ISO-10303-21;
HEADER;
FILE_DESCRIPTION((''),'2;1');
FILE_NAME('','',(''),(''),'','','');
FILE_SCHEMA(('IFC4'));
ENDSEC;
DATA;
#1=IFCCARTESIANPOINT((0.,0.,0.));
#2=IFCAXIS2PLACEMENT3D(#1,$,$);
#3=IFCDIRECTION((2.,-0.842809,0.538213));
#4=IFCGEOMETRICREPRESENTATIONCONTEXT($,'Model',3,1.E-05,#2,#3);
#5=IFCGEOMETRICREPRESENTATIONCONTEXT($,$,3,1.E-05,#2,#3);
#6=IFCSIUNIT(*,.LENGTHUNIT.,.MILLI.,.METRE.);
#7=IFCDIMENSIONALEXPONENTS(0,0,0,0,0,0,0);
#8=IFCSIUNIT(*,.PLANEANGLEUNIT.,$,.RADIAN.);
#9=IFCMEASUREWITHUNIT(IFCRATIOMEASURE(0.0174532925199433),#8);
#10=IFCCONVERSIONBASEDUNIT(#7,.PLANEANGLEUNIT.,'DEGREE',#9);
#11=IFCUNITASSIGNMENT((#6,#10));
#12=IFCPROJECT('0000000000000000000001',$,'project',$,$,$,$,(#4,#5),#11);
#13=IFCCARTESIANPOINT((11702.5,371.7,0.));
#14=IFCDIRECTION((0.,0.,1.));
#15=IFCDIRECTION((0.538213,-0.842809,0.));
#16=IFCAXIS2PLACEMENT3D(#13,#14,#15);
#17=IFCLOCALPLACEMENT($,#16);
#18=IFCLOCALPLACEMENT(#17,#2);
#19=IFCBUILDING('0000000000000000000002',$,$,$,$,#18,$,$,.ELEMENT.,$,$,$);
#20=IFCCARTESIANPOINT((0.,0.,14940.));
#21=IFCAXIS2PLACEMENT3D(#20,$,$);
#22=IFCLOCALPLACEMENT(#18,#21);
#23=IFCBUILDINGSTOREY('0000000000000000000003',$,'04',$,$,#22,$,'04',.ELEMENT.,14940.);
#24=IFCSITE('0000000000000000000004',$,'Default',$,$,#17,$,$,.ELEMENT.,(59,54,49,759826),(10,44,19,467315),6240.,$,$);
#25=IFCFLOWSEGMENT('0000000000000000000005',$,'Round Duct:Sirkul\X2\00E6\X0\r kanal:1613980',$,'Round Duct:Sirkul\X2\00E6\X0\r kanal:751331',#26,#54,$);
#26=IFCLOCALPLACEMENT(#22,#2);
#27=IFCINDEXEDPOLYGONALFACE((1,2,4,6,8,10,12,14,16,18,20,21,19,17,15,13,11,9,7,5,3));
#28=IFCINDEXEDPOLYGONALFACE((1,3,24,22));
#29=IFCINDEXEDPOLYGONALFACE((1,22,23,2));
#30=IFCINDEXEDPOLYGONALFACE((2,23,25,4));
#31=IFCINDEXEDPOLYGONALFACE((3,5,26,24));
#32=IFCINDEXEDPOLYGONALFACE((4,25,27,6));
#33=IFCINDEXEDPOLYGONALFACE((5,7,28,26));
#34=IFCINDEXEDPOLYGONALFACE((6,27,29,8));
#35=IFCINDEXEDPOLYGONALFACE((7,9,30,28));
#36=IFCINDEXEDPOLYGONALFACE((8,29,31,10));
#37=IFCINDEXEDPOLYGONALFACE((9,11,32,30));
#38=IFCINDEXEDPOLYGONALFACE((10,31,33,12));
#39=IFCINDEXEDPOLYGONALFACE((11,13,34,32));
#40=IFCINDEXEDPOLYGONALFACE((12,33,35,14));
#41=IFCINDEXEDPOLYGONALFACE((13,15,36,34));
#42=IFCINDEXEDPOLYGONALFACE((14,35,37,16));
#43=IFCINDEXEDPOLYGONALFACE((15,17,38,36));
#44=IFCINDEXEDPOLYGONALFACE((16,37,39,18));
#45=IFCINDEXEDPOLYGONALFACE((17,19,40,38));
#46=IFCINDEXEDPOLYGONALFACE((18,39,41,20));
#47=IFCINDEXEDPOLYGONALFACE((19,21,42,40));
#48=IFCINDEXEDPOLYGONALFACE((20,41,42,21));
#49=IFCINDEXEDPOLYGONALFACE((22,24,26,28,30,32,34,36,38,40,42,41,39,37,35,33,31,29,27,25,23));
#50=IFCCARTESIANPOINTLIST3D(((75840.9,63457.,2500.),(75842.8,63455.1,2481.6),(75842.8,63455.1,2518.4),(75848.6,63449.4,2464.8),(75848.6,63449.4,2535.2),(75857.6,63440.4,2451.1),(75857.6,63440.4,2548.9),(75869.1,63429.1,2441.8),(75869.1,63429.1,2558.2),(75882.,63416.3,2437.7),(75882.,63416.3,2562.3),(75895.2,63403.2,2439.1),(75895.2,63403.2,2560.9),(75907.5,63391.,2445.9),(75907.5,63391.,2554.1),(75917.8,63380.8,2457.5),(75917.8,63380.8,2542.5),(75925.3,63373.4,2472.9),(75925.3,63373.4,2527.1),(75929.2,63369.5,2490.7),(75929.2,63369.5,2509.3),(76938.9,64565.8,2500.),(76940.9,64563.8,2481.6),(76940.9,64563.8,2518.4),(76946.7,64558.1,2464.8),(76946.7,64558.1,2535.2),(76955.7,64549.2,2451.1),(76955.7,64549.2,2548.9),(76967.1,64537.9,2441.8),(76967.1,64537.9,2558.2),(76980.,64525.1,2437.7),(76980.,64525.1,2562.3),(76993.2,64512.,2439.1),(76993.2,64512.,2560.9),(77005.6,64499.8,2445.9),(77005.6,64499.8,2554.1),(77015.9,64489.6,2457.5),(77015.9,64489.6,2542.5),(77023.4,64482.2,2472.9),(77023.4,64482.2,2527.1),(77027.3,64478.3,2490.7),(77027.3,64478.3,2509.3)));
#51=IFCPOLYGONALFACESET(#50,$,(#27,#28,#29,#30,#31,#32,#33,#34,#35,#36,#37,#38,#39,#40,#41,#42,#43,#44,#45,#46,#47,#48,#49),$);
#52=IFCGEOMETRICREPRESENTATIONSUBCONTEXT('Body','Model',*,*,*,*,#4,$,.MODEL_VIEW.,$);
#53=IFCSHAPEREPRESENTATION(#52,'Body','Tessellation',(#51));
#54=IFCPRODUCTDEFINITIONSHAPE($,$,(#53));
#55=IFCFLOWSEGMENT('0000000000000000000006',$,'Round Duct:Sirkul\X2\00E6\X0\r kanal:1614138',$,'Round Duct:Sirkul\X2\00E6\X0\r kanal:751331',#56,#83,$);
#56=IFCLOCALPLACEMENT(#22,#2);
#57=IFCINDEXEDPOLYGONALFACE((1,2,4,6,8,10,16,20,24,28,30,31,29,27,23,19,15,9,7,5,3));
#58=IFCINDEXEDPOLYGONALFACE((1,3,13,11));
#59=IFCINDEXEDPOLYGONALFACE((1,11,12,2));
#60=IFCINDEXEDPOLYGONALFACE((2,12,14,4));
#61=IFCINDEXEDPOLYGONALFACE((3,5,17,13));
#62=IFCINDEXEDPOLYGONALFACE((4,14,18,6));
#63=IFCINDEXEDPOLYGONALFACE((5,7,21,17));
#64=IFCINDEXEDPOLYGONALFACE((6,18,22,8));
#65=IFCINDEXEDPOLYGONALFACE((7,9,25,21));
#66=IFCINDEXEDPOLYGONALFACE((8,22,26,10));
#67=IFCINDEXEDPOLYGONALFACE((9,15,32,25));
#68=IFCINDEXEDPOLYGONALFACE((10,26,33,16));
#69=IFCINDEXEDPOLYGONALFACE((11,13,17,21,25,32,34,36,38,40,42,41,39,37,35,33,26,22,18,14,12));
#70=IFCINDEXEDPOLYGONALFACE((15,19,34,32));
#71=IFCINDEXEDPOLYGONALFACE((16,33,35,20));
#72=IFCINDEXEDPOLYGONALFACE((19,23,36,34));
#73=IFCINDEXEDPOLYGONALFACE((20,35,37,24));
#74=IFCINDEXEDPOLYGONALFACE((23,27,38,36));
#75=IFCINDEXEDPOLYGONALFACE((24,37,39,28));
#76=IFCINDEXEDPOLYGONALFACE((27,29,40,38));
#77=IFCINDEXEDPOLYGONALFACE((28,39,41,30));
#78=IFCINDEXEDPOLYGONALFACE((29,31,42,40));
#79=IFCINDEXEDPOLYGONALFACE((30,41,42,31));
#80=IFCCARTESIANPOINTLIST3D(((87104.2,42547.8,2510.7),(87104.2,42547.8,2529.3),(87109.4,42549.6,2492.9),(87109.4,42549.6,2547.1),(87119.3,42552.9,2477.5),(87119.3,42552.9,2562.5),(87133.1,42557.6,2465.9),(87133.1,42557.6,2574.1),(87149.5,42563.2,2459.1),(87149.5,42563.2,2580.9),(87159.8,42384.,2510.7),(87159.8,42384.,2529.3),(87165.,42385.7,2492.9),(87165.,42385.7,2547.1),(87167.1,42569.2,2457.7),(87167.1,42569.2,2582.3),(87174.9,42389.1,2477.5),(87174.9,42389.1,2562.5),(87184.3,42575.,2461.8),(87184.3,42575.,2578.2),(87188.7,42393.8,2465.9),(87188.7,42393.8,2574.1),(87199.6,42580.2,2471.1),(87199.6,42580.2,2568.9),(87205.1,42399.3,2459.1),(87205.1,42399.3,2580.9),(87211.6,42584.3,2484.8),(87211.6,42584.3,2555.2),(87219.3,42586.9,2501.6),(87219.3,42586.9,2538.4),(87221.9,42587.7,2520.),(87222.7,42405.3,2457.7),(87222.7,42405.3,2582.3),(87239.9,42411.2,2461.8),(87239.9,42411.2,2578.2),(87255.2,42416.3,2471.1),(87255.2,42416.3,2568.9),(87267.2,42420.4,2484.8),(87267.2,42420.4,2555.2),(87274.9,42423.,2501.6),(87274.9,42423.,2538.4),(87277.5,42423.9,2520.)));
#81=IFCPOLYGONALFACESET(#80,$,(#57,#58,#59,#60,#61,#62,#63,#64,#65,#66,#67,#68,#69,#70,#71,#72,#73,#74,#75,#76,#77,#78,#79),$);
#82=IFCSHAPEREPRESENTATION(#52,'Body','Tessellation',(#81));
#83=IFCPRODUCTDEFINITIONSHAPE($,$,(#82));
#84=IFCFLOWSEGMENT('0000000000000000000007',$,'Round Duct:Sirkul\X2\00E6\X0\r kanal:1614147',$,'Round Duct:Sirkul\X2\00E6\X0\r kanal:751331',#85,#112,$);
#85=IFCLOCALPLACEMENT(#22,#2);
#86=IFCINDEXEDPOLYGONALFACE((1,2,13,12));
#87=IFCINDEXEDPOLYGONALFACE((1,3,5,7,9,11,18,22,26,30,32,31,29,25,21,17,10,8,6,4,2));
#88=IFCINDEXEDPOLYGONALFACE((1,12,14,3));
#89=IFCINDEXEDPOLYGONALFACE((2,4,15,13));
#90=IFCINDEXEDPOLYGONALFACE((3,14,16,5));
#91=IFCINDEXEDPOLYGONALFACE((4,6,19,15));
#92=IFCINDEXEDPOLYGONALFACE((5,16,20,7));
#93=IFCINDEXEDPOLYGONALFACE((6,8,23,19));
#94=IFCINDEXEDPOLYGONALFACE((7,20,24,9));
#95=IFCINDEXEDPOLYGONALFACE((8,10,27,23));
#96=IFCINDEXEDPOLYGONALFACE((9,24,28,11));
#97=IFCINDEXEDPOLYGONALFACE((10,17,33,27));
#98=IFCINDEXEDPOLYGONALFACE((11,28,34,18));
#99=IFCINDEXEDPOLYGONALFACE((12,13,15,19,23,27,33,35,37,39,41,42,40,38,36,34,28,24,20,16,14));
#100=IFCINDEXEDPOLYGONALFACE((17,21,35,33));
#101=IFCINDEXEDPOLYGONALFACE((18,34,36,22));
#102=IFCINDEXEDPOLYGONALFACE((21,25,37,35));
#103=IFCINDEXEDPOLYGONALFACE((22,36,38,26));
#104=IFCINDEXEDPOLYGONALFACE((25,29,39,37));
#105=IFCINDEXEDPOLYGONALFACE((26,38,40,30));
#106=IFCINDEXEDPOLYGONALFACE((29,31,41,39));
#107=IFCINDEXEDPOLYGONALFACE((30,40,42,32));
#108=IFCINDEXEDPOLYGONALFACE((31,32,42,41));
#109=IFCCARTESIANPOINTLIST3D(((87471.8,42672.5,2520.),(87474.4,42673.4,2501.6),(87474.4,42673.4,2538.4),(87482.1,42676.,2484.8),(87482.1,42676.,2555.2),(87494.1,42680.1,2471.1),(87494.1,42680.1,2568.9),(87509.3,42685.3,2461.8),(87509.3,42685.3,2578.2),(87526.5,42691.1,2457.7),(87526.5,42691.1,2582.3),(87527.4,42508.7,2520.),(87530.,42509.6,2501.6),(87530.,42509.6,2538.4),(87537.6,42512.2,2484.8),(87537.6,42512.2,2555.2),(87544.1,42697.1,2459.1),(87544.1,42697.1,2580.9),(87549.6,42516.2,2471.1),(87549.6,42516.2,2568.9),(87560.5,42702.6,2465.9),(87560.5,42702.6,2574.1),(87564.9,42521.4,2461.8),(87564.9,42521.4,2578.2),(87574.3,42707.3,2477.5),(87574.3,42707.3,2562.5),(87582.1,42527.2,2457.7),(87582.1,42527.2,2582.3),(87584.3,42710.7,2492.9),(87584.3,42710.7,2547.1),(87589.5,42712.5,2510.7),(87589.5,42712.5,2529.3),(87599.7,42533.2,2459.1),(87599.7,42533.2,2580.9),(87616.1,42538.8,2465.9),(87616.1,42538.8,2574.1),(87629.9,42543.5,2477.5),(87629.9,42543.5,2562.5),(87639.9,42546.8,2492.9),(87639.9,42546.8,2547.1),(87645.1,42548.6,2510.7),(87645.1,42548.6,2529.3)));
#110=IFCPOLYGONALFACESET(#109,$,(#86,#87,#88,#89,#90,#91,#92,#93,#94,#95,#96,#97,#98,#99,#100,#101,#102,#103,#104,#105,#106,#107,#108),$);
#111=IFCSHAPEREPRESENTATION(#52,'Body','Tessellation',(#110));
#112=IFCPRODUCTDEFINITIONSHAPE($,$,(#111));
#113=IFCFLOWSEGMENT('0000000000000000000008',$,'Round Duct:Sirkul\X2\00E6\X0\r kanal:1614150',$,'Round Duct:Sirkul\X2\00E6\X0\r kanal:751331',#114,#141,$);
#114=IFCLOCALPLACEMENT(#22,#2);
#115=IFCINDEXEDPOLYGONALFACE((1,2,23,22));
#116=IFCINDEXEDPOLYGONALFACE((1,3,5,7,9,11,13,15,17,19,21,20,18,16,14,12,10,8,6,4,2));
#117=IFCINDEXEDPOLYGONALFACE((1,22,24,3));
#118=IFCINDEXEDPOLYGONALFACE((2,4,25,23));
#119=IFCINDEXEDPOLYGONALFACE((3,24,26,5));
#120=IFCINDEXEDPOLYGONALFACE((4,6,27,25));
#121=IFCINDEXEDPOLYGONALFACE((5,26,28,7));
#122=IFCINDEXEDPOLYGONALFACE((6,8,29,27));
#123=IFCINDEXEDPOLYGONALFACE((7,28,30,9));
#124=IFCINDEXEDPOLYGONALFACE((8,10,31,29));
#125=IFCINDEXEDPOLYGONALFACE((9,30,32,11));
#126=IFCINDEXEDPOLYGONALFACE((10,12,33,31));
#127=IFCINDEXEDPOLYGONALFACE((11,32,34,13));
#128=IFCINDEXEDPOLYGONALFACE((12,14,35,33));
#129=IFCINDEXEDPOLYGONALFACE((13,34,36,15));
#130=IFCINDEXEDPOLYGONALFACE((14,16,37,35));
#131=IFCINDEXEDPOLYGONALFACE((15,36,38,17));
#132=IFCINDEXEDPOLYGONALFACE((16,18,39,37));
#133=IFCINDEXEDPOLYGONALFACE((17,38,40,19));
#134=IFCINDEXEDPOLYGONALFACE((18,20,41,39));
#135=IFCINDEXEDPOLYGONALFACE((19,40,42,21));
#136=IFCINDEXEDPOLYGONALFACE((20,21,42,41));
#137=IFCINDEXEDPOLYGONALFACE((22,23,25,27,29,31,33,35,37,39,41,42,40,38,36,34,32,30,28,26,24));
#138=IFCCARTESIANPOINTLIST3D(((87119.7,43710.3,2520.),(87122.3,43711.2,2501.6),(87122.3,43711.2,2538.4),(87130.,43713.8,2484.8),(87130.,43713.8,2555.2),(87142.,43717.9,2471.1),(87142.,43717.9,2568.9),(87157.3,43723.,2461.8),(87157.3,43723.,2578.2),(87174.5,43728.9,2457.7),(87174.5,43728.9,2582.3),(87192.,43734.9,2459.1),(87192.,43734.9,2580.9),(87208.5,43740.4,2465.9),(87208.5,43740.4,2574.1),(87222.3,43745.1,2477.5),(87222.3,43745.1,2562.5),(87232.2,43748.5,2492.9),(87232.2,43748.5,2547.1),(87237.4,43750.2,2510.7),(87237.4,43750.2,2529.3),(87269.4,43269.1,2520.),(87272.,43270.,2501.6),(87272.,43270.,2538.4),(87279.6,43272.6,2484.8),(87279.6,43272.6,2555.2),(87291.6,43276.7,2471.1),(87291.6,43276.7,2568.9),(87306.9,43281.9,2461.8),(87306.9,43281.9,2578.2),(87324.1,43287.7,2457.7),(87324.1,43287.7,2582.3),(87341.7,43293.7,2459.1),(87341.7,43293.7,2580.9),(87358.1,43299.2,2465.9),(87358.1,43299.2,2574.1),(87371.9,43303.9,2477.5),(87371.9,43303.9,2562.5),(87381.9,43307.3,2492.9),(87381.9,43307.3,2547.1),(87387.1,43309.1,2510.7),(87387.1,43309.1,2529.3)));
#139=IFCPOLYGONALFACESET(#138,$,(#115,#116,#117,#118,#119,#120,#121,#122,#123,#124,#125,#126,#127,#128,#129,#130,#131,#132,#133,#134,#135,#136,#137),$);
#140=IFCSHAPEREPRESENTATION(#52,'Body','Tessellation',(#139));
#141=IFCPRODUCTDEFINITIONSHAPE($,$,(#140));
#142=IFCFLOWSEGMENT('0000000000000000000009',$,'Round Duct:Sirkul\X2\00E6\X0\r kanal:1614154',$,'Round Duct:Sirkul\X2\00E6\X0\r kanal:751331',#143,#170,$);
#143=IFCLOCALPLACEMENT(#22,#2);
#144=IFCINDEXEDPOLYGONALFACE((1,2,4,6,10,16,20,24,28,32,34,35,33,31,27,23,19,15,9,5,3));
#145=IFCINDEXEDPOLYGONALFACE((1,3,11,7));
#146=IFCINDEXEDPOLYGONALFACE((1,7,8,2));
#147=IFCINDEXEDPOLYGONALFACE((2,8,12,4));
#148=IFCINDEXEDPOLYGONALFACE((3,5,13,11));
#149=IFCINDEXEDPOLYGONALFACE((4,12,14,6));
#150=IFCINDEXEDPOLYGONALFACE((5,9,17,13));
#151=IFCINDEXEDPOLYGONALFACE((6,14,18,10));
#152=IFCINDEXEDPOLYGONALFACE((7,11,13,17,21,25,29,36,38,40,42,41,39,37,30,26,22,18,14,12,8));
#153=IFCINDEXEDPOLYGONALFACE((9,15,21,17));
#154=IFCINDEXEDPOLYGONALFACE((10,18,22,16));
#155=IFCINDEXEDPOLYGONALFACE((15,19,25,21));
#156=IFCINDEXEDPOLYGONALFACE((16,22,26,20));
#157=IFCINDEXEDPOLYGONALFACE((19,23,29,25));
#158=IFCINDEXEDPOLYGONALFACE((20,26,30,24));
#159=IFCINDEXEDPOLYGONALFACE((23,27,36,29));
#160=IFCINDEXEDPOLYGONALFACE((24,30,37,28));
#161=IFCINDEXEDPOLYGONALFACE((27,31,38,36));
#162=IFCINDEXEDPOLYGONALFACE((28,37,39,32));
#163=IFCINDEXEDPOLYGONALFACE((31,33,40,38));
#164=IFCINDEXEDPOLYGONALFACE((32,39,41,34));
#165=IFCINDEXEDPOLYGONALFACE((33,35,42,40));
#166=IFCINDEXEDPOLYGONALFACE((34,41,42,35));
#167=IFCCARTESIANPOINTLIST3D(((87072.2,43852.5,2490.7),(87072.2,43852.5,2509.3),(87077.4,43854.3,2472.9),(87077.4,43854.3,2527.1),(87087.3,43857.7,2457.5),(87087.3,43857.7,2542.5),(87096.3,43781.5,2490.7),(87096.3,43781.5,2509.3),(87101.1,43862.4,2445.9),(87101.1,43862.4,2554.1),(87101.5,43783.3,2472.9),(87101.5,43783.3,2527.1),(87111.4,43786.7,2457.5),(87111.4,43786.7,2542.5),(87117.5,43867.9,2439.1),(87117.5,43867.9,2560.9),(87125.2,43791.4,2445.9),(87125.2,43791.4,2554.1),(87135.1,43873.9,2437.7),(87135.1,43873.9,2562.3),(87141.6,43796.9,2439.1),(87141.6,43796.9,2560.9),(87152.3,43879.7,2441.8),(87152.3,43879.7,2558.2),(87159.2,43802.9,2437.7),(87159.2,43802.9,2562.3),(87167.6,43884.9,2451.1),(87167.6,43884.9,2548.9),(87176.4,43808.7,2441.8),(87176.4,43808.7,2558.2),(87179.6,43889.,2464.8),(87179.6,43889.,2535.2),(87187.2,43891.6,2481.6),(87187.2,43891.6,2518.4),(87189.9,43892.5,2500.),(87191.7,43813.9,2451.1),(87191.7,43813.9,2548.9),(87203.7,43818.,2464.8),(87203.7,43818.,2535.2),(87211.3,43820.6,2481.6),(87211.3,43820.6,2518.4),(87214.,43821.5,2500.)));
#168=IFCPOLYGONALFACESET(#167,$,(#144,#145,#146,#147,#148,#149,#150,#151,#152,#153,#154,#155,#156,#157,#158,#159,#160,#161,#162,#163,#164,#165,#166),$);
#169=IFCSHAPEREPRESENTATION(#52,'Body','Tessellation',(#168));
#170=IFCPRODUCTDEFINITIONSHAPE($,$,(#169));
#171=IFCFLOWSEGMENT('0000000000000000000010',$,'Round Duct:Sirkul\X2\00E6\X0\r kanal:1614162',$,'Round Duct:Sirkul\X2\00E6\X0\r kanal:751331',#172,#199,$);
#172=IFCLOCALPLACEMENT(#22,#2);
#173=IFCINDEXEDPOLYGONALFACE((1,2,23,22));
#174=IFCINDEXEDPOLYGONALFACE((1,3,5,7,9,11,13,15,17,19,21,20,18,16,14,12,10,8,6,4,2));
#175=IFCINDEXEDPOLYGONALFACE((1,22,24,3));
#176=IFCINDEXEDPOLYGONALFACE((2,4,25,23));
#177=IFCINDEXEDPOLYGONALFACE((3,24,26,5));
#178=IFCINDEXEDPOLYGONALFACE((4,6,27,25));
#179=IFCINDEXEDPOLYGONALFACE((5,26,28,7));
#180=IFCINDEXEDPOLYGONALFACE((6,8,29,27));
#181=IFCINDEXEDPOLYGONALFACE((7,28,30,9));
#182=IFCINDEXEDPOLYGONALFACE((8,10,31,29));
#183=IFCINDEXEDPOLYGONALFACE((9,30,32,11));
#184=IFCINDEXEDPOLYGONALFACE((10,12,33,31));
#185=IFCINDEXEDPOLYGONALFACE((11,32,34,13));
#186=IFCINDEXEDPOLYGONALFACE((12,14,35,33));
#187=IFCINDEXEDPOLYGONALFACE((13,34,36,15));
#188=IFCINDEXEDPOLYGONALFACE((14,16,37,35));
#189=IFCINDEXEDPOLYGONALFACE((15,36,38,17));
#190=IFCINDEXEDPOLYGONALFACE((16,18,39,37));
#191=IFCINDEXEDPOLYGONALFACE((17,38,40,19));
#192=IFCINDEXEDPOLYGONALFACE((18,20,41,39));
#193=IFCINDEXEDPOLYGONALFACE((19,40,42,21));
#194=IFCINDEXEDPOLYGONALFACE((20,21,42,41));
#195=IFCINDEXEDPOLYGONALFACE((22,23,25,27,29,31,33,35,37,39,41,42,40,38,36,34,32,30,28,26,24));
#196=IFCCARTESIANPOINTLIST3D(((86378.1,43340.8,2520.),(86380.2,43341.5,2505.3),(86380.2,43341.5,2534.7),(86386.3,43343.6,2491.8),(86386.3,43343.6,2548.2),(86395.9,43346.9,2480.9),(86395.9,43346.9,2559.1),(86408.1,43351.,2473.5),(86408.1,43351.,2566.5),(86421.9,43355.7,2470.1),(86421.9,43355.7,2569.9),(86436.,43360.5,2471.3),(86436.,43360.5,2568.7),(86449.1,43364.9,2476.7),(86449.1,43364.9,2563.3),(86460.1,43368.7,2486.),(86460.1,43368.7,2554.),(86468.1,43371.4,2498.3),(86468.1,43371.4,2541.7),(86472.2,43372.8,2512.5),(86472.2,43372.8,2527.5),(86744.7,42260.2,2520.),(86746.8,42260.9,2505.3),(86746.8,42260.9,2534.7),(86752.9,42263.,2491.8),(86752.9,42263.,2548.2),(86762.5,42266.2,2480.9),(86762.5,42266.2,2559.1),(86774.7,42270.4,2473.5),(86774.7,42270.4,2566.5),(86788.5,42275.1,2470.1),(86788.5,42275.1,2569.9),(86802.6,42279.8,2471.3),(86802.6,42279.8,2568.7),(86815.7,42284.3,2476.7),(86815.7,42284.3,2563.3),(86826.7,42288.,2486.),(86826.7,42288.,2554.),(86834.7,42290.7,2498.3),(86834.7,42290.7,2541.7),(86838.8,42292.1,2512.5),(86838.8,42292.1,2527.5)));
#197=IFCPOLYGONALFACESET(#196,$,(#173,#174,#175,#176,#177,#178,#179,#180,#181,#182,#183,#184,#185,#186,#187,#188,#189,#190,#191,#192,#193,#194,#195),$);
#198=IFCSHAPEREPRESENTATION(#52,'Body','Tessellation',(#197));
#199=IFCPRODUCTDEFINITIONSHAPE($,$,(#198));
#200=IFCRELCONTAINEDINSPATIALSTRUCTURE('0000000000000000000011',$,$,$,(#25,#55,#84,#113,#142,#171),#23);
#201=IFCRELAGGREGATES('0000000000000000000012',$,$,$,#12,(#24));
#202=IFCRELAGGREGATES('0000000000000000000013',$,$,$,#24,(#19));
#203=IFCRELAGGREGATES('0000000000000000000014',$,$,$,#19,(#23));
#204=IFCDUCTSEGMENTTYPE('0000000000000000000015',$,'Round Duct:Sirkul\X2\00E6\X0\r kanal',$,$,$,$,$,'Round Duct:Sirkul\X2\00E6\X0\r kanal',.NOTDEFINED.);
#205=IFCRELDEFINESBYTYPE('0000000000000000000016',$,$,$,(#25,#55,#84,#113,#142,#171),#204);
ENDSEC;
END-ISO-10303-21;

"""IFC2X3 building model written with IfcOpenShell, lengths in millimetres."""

from ifc_helpers import new_model, entity, si_unit, converted_unit, direction, frame, origin, origin_2d_with_axis, place, context, subcontext, project, spatial, circle, extrude, type_object, element, save


model = new_model("IFC2X3")

# Units and contexts
model_context = context("Model", 3, precision=1e-05, world=origin(), true_north=direction((2.0, -0.842809, 0.538213)))
context_of_model = context(None, 3, precision=1e-05, world=origin(), true_north=direction((2.0, -0.842809, 0.538213)))
body_context = subcontext(model_context, "Body", "Model", "MODEL_VIEW")
ifc_project = project(units=[si_unit("LENGTHUNIT", "METRE", prefix="MILLI"), converted_unit("PLANEANGLEUNIT", "DEGREE", entity("IfcRatioMeasure", 0.0174532925199433), si_unit("PLANEANGLEUNIT", "RADIAN"), dimensions=[0, 0, 0, 0, 0, 0, 0])], contexts=[model_context, context_of_model])

# Site, building, storey
site_placement = place(None, frame((11702.5, 371.7, 0.0), z_axis=(0.0, 0.0, 1.0), x_axis=(0.538213, -0.842809, 0.0)))
site = spatial("IfcSite", under=ifc_project, at=site_placement, Name="Default", CompositionType="ELEMENT", RefLatitude=(59, 54, 49, 759826), RefLongitude=(10, 44, 19, 467315), RefElevation=6240.0)
building_placement = place(site_placement, origin())
building = spatial("IfcBuilding", under=site, at=building_placement, CompositionType="ELEMENT")
storey_placement = place(building_placement, frame((0.0, 0.0, 14940.0)))
storey = spatial("IfcBuildingStorey", under=building, at=storey_placement, Name="04", LongName="04", CompositionType="ELEMENT", Elevation=14940.0)

# Flow segments
duct_segment_type = type_object("IfcDuctSegmentType", Name="Round Duct:Sirkulær kanal", ElementType="Round Duct:Sirkulær kanal", PredefinedType="NOTDEFINED")
flow_segment_1_placement = place(storey_placement, origin())
element("IfcFlowSegment", 1, at=flow_segment_1_placement, inside=storey, type_object=duct_segment_type, Name="Round Duct:Sirkulær kanal:1613980", ObjectType="Round Duct:Sirkulær kanal:751331", context=body_context, shape_type="SweptSolid", body=[
    extrude(circle(Radius=62.5, at=origin_2d_with_axis()), frame((75885.3, 63413.0, 2500.0), z_axis=(0.703669, 0.710528, 0.0), x_axis=(-0.710528, 0.703669, 0.0)), (0.0, 0.0, 1.0), 1560.5),
])
flow_segment_2_placement = place(storey_placement, origin())
element("IfcFlowSegment", 2, at=flow_segment_2_placement, inside=storey, type_object=duct_segment_type, Name="Round Duct:Sirkulær kanal:1614138", ObjectType="Round Duct:Sirkulær kanal:751331", context=body_context, shape_type="SweptSolid", body=[
    extrude(circle(Radius=62.5, at=origin_2d_with_axis()), frame((87162.7, 42567.7, 2520.0), z_axis=(0.321274, -0.946986, 0.0), x_axis=(0.946986, 0.321274, 0.0)), (0.0, 0.0, 1.0), 173.0),
])
flow_segment_3_placement = place(storey_placement, origin())
element("IfcFlowSegment", 3, at=flow_segment_3_placement, inside=storey, type_object=duct_segment_type, Name="Round Duct:Sirkulær kanal:1614147", ObjectType="Round Duct:Sirkulær kanal:751331", context=body_context, shape_type="SweptSolid", body=[
    extrude(circle(Radius=62.5, at=origin_2d_with_axis()), frame((87586.5, 42528.7, 2520.0), z_axis=(-0.321274, 0.946986, 0.0), x_axis=(-0.946986, -0.321274, 0.0)), (0.0, 0.0, 1.0), 173.0),
])
flow_segment_4_placement = place(storey_placement, origin())
element("IfcFlowSegment", 4, at=flow_segment_4_placement, inside=storey, type_object=duct_segment_type, Name="Round Duct:Sirkulær kanal:1614150", ObjectType="Round Duct:Sirkulær kanal:751331", context=body_context, shape_type="SweptSolid", body=[
    extrude(circle(Radius=62.5, at=origin_2d_with_axis()), frame((87328.6, 43289.2, 2520.0), z_axis=(-0.321274, 0.946986, 0.0), x_axis=(-0.946986, -0.321274, 0.0)), (0.0, 0.0, 1.0), 465.9),
])
flow_segment_5_placement = place(storey_placement, origin())
element("IfcFlowSegment", 5, at=flow_segment_5_placement, inside=storey, type_object=duct_segment_type, Name="Round Duct:Sirkulær kanal:1614154", ObjectType="Round Duct:Sirkulær kanal:751331", context=body_context, shape_type="SweptSolid", body=[
    extrude(circle(Radius=62.5, at=origin_2d_with_axis()), frame((87130.7, 43872.4, 2500.0), z_axis=(0.321446, -0.946928, 0.0), x_axis=(0.946928, 0.321446, 0.0)), (0.0, 0.0, 1.0), 75.0),
])
flow_segment_6_placement = place(storey_placement, origin())
element("IfcFlowSegment", 6, at=flow_segment_6_placement, inside=storey, type_object=duct_segment_type, Name="Round Duct:Sirkulær kanal:1614162", ObjectType="Round Duct:Sirkulær kanal:751331", context=body_context, shape_type="SweptSolid", body=[
    extrude(circle(Radius=50.0, at=origin_2d_with_axis()), frame((86425.4, 43356.9, 2520.0), z_axis=(0.321274, -0.946986, 0.0), x_axis=(-0.946986, -0.321274, 0.0)), (0.0, 0.0, 1.0), 1141.1),
])

save(model, "model.ifc")
